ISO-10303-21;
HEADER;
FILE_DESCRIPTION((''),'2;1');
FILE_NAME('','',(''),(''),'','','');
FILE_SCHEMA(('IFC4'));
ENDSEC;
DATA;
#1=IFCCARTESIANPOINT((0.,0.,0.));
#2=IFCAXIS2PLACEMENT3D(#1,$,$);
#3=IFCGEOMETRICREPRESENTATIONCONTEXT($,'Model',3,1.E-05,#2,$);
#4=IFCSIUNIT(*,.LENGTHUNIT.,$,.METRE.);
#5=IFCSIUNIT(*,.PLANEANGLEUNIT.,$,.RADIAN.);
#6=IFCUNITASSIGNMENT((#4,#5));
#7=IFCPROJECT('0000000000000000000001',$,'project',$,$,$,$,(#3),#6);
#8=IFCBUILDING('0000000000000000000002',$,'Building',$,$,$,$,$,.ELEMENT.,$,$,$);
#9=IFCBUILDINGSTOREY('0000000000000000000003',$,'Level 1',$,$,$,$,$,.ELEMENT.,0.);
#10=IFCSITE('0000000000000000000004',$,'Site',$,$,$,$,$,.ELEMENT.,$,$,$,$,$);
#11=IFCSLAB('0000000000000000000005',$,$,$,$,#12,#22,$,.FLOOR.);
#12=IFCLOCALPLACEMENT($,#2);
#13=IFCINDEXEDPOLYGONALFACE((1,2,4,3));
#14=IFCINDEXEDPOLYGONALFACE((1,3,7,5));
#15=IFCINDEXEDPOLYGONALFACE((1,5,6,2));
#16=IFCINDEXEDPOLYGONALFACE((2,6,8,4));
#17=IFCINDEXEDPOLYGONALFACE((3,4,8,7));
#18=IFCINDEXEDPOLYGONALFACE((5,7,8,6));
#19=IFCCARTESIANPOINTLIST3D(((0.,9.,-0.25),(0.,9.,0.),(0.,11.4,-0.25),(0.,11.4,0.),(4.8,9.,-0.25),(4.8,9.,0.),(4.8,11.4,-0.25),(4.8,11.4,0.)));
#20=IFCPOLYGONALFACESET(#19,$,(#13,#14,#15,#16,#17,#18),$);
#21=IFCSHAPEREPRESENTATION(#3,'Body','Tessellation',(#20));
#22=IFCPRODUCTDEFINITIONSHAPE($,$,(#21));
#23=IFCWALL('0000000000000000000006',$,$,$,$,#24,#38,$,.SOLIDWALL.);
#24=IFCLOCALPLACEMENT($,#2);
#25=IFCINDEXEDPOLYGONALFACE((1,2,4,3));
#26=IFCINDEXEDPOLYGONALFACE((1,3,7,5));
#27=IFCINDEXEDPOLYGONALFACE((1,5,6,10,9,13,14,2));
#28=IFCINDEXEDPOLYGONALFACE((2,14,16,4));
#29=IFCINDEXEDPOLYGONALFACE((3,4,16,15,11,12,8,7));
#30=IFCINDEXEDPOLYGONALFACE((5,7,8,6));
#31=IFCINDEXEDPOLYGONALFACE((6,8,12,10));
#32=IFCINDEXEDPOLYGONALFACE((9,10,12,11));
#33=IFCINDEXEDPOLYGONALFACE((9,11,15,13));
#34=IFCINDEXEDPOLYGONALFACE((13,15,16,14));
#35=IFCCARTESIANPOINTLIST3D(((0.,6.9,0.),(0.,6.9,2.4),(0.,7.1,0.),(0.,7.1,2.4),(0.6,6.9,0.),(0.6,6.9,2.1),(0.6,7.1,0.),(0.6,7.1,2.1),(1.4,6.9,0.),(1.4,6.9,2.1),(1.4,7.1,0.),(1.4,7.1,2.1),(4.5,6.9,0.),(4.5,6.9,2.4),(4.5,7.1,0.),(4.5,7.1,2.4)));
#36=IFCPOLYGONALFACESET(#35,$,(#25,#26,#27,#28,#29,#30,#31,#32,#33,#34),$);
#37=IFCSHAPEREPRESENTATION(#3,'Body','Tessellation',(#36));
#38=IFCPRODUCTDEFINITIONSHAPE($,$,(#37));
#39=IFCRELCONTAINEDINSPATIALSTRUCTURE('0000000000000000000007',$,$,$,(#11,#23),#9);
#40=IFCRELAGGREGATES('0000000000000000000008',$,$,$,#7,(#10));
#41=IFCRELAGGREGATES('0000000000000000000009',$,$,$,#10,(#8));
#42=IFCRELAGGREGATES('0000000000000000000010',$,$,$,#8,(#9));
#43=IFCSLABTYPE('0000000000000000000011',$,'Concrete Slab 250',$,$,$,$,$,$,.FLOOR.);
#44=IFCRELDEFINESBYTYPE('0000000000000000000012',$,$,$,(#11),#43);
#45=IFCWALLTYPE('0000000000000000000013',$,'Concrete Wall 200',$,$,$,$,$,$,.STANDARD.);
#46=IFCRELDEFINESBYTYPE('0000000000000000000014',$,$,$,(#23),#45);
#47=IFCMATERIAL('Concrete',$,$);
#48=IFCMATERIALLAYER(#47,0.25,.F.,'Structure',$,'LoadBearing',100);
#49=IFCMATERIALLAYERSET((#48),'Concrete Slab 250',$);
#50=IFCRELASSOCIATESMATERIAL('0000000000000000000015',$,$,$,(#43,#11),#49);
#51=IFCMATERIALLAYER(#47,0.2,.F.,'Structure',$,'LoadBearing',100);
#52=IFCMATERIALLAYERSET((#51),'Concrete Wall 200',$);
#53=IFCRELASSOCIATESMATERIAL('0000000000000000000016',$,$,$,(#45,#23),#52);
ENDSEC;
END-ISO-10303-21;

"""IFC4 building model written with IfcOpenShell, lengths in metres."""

from ifc_helpers import new_model, si_unit, frame, frame_2d, origin, origin_2d, place, context, project, spatial, polyline, rectangle, outline, extrude, material, layer, layer_set, layer_usage, type_object, element, save


model = new_model("IFC4")

# Units and contexts
model_context = context("Model", 3, precision=1e-05, world=origin())
ifc_project = project(units=[si_unit("LENGTHUNIT", "METRE"), si_unit("PLANEANGLEUNIT", "RADIAN")], contexts=[model_context])

# Site, building, storey
site = spatial("IfcSite", under=ifc_project, Name="Site", CompositionType="ELEMENT")
building = spatial("IfcBuilding", under=site, Name="Building", CompositionType="ELEMENT")
storey = spatial("IfcBuildingStorey", under=building, Name="Level 1", CompositionType="ELEMENT", Elevation=0.0)

# Slab
ifc_material = material(Name="Concrete")
ifc_layer_1 = layer(ifc_material, 0.25, ventilated=False, Name="Structure", Category="LoadBearing", Priority=100)
ifc_layer_set_1 = layer_set([ifc_layer_1], Name="Concrete Slab 250")
ifc_layer_usage_1 = layer_usage(ifc_layer_set_1, "AXIS3", "NEGATIVE", 0.0)
slab_type = type_object("IfcSlabType", Name="Concrete Slab 250", PredefinedType="FLOOR", material=ifc_layer_set_1)
slab_placement = place(None, origin())
element("IfcSlab", 1, at=slab_placement, inside=storey, type_object=slab_type, material=ifc_layer_usage_1, PredefinedType="FLOOR", context=model_context, shape_type="SweptSolid", body=[
    extrude(outline(polyline([(0.0, 9.0), (4.8, 9.0), (4.8, 11.4), (0.0, 11.4), (0.0, 9.0)])), origin(), (0.0, 0.0, -1.0), 0.25),
])

# Wall, opening
ifc_layer_2 = layer(ifc_material, 0.2, ventilated=False, Name="Structure", Category="LoadBearing", Priority=100)
ifc_layer_set_2 = layer_set([ifc_layer_2], Name="Concrete Wall 200")
ifc_layer_usage_2 = layer_usage(ifc_layer_set_2, "AXIS2", "POSITIVE", -0.1)
wall_type = type_object("IfcWallType", Name="Concrete Wall 200", PredefinedType="STANDARD", material=ifc_layer_set_2)
wall_placement = place(None, frame((0.0, 7.0, 0.0), z_axis=(0.0, 0.0, 1.0), x_axis=(1.0, 0.0, 0.0)))
wall = element("IfcWall", 2, at=wall_placement, inside=storey, type_object=wall_type, material=ifc_layer_usage_2, PredefinedType="SOLIDWALL", context=model_context, shape_type="SweptSolid", body=[
    extrude(rectangle(XDim=4.5, YDim=0.2, at=frame_2d((2.25, 0.0))), origin(), (0.0, 0.0, 1.0), 2.4),
])
opening_placement = place(wall_placement, frame((1.0, 0.0, 0.0), z_axis=(0.0, 0.0, 1.0), x_axis=(1.0, 0.0, 0.0)))
element("IfcOpeningElement", 3, at=opening_placement, cuts=wall, PredefinedType="OPENING", context=model_context, shape_type="SweptSolid", body=[
    extrude(rectangle(XDim=0.8, YDim=0.202, at=origin_2d()), origin(), (0.0, 0.0, 1.0), 2.1),
])

save(model, "model.ifc")
